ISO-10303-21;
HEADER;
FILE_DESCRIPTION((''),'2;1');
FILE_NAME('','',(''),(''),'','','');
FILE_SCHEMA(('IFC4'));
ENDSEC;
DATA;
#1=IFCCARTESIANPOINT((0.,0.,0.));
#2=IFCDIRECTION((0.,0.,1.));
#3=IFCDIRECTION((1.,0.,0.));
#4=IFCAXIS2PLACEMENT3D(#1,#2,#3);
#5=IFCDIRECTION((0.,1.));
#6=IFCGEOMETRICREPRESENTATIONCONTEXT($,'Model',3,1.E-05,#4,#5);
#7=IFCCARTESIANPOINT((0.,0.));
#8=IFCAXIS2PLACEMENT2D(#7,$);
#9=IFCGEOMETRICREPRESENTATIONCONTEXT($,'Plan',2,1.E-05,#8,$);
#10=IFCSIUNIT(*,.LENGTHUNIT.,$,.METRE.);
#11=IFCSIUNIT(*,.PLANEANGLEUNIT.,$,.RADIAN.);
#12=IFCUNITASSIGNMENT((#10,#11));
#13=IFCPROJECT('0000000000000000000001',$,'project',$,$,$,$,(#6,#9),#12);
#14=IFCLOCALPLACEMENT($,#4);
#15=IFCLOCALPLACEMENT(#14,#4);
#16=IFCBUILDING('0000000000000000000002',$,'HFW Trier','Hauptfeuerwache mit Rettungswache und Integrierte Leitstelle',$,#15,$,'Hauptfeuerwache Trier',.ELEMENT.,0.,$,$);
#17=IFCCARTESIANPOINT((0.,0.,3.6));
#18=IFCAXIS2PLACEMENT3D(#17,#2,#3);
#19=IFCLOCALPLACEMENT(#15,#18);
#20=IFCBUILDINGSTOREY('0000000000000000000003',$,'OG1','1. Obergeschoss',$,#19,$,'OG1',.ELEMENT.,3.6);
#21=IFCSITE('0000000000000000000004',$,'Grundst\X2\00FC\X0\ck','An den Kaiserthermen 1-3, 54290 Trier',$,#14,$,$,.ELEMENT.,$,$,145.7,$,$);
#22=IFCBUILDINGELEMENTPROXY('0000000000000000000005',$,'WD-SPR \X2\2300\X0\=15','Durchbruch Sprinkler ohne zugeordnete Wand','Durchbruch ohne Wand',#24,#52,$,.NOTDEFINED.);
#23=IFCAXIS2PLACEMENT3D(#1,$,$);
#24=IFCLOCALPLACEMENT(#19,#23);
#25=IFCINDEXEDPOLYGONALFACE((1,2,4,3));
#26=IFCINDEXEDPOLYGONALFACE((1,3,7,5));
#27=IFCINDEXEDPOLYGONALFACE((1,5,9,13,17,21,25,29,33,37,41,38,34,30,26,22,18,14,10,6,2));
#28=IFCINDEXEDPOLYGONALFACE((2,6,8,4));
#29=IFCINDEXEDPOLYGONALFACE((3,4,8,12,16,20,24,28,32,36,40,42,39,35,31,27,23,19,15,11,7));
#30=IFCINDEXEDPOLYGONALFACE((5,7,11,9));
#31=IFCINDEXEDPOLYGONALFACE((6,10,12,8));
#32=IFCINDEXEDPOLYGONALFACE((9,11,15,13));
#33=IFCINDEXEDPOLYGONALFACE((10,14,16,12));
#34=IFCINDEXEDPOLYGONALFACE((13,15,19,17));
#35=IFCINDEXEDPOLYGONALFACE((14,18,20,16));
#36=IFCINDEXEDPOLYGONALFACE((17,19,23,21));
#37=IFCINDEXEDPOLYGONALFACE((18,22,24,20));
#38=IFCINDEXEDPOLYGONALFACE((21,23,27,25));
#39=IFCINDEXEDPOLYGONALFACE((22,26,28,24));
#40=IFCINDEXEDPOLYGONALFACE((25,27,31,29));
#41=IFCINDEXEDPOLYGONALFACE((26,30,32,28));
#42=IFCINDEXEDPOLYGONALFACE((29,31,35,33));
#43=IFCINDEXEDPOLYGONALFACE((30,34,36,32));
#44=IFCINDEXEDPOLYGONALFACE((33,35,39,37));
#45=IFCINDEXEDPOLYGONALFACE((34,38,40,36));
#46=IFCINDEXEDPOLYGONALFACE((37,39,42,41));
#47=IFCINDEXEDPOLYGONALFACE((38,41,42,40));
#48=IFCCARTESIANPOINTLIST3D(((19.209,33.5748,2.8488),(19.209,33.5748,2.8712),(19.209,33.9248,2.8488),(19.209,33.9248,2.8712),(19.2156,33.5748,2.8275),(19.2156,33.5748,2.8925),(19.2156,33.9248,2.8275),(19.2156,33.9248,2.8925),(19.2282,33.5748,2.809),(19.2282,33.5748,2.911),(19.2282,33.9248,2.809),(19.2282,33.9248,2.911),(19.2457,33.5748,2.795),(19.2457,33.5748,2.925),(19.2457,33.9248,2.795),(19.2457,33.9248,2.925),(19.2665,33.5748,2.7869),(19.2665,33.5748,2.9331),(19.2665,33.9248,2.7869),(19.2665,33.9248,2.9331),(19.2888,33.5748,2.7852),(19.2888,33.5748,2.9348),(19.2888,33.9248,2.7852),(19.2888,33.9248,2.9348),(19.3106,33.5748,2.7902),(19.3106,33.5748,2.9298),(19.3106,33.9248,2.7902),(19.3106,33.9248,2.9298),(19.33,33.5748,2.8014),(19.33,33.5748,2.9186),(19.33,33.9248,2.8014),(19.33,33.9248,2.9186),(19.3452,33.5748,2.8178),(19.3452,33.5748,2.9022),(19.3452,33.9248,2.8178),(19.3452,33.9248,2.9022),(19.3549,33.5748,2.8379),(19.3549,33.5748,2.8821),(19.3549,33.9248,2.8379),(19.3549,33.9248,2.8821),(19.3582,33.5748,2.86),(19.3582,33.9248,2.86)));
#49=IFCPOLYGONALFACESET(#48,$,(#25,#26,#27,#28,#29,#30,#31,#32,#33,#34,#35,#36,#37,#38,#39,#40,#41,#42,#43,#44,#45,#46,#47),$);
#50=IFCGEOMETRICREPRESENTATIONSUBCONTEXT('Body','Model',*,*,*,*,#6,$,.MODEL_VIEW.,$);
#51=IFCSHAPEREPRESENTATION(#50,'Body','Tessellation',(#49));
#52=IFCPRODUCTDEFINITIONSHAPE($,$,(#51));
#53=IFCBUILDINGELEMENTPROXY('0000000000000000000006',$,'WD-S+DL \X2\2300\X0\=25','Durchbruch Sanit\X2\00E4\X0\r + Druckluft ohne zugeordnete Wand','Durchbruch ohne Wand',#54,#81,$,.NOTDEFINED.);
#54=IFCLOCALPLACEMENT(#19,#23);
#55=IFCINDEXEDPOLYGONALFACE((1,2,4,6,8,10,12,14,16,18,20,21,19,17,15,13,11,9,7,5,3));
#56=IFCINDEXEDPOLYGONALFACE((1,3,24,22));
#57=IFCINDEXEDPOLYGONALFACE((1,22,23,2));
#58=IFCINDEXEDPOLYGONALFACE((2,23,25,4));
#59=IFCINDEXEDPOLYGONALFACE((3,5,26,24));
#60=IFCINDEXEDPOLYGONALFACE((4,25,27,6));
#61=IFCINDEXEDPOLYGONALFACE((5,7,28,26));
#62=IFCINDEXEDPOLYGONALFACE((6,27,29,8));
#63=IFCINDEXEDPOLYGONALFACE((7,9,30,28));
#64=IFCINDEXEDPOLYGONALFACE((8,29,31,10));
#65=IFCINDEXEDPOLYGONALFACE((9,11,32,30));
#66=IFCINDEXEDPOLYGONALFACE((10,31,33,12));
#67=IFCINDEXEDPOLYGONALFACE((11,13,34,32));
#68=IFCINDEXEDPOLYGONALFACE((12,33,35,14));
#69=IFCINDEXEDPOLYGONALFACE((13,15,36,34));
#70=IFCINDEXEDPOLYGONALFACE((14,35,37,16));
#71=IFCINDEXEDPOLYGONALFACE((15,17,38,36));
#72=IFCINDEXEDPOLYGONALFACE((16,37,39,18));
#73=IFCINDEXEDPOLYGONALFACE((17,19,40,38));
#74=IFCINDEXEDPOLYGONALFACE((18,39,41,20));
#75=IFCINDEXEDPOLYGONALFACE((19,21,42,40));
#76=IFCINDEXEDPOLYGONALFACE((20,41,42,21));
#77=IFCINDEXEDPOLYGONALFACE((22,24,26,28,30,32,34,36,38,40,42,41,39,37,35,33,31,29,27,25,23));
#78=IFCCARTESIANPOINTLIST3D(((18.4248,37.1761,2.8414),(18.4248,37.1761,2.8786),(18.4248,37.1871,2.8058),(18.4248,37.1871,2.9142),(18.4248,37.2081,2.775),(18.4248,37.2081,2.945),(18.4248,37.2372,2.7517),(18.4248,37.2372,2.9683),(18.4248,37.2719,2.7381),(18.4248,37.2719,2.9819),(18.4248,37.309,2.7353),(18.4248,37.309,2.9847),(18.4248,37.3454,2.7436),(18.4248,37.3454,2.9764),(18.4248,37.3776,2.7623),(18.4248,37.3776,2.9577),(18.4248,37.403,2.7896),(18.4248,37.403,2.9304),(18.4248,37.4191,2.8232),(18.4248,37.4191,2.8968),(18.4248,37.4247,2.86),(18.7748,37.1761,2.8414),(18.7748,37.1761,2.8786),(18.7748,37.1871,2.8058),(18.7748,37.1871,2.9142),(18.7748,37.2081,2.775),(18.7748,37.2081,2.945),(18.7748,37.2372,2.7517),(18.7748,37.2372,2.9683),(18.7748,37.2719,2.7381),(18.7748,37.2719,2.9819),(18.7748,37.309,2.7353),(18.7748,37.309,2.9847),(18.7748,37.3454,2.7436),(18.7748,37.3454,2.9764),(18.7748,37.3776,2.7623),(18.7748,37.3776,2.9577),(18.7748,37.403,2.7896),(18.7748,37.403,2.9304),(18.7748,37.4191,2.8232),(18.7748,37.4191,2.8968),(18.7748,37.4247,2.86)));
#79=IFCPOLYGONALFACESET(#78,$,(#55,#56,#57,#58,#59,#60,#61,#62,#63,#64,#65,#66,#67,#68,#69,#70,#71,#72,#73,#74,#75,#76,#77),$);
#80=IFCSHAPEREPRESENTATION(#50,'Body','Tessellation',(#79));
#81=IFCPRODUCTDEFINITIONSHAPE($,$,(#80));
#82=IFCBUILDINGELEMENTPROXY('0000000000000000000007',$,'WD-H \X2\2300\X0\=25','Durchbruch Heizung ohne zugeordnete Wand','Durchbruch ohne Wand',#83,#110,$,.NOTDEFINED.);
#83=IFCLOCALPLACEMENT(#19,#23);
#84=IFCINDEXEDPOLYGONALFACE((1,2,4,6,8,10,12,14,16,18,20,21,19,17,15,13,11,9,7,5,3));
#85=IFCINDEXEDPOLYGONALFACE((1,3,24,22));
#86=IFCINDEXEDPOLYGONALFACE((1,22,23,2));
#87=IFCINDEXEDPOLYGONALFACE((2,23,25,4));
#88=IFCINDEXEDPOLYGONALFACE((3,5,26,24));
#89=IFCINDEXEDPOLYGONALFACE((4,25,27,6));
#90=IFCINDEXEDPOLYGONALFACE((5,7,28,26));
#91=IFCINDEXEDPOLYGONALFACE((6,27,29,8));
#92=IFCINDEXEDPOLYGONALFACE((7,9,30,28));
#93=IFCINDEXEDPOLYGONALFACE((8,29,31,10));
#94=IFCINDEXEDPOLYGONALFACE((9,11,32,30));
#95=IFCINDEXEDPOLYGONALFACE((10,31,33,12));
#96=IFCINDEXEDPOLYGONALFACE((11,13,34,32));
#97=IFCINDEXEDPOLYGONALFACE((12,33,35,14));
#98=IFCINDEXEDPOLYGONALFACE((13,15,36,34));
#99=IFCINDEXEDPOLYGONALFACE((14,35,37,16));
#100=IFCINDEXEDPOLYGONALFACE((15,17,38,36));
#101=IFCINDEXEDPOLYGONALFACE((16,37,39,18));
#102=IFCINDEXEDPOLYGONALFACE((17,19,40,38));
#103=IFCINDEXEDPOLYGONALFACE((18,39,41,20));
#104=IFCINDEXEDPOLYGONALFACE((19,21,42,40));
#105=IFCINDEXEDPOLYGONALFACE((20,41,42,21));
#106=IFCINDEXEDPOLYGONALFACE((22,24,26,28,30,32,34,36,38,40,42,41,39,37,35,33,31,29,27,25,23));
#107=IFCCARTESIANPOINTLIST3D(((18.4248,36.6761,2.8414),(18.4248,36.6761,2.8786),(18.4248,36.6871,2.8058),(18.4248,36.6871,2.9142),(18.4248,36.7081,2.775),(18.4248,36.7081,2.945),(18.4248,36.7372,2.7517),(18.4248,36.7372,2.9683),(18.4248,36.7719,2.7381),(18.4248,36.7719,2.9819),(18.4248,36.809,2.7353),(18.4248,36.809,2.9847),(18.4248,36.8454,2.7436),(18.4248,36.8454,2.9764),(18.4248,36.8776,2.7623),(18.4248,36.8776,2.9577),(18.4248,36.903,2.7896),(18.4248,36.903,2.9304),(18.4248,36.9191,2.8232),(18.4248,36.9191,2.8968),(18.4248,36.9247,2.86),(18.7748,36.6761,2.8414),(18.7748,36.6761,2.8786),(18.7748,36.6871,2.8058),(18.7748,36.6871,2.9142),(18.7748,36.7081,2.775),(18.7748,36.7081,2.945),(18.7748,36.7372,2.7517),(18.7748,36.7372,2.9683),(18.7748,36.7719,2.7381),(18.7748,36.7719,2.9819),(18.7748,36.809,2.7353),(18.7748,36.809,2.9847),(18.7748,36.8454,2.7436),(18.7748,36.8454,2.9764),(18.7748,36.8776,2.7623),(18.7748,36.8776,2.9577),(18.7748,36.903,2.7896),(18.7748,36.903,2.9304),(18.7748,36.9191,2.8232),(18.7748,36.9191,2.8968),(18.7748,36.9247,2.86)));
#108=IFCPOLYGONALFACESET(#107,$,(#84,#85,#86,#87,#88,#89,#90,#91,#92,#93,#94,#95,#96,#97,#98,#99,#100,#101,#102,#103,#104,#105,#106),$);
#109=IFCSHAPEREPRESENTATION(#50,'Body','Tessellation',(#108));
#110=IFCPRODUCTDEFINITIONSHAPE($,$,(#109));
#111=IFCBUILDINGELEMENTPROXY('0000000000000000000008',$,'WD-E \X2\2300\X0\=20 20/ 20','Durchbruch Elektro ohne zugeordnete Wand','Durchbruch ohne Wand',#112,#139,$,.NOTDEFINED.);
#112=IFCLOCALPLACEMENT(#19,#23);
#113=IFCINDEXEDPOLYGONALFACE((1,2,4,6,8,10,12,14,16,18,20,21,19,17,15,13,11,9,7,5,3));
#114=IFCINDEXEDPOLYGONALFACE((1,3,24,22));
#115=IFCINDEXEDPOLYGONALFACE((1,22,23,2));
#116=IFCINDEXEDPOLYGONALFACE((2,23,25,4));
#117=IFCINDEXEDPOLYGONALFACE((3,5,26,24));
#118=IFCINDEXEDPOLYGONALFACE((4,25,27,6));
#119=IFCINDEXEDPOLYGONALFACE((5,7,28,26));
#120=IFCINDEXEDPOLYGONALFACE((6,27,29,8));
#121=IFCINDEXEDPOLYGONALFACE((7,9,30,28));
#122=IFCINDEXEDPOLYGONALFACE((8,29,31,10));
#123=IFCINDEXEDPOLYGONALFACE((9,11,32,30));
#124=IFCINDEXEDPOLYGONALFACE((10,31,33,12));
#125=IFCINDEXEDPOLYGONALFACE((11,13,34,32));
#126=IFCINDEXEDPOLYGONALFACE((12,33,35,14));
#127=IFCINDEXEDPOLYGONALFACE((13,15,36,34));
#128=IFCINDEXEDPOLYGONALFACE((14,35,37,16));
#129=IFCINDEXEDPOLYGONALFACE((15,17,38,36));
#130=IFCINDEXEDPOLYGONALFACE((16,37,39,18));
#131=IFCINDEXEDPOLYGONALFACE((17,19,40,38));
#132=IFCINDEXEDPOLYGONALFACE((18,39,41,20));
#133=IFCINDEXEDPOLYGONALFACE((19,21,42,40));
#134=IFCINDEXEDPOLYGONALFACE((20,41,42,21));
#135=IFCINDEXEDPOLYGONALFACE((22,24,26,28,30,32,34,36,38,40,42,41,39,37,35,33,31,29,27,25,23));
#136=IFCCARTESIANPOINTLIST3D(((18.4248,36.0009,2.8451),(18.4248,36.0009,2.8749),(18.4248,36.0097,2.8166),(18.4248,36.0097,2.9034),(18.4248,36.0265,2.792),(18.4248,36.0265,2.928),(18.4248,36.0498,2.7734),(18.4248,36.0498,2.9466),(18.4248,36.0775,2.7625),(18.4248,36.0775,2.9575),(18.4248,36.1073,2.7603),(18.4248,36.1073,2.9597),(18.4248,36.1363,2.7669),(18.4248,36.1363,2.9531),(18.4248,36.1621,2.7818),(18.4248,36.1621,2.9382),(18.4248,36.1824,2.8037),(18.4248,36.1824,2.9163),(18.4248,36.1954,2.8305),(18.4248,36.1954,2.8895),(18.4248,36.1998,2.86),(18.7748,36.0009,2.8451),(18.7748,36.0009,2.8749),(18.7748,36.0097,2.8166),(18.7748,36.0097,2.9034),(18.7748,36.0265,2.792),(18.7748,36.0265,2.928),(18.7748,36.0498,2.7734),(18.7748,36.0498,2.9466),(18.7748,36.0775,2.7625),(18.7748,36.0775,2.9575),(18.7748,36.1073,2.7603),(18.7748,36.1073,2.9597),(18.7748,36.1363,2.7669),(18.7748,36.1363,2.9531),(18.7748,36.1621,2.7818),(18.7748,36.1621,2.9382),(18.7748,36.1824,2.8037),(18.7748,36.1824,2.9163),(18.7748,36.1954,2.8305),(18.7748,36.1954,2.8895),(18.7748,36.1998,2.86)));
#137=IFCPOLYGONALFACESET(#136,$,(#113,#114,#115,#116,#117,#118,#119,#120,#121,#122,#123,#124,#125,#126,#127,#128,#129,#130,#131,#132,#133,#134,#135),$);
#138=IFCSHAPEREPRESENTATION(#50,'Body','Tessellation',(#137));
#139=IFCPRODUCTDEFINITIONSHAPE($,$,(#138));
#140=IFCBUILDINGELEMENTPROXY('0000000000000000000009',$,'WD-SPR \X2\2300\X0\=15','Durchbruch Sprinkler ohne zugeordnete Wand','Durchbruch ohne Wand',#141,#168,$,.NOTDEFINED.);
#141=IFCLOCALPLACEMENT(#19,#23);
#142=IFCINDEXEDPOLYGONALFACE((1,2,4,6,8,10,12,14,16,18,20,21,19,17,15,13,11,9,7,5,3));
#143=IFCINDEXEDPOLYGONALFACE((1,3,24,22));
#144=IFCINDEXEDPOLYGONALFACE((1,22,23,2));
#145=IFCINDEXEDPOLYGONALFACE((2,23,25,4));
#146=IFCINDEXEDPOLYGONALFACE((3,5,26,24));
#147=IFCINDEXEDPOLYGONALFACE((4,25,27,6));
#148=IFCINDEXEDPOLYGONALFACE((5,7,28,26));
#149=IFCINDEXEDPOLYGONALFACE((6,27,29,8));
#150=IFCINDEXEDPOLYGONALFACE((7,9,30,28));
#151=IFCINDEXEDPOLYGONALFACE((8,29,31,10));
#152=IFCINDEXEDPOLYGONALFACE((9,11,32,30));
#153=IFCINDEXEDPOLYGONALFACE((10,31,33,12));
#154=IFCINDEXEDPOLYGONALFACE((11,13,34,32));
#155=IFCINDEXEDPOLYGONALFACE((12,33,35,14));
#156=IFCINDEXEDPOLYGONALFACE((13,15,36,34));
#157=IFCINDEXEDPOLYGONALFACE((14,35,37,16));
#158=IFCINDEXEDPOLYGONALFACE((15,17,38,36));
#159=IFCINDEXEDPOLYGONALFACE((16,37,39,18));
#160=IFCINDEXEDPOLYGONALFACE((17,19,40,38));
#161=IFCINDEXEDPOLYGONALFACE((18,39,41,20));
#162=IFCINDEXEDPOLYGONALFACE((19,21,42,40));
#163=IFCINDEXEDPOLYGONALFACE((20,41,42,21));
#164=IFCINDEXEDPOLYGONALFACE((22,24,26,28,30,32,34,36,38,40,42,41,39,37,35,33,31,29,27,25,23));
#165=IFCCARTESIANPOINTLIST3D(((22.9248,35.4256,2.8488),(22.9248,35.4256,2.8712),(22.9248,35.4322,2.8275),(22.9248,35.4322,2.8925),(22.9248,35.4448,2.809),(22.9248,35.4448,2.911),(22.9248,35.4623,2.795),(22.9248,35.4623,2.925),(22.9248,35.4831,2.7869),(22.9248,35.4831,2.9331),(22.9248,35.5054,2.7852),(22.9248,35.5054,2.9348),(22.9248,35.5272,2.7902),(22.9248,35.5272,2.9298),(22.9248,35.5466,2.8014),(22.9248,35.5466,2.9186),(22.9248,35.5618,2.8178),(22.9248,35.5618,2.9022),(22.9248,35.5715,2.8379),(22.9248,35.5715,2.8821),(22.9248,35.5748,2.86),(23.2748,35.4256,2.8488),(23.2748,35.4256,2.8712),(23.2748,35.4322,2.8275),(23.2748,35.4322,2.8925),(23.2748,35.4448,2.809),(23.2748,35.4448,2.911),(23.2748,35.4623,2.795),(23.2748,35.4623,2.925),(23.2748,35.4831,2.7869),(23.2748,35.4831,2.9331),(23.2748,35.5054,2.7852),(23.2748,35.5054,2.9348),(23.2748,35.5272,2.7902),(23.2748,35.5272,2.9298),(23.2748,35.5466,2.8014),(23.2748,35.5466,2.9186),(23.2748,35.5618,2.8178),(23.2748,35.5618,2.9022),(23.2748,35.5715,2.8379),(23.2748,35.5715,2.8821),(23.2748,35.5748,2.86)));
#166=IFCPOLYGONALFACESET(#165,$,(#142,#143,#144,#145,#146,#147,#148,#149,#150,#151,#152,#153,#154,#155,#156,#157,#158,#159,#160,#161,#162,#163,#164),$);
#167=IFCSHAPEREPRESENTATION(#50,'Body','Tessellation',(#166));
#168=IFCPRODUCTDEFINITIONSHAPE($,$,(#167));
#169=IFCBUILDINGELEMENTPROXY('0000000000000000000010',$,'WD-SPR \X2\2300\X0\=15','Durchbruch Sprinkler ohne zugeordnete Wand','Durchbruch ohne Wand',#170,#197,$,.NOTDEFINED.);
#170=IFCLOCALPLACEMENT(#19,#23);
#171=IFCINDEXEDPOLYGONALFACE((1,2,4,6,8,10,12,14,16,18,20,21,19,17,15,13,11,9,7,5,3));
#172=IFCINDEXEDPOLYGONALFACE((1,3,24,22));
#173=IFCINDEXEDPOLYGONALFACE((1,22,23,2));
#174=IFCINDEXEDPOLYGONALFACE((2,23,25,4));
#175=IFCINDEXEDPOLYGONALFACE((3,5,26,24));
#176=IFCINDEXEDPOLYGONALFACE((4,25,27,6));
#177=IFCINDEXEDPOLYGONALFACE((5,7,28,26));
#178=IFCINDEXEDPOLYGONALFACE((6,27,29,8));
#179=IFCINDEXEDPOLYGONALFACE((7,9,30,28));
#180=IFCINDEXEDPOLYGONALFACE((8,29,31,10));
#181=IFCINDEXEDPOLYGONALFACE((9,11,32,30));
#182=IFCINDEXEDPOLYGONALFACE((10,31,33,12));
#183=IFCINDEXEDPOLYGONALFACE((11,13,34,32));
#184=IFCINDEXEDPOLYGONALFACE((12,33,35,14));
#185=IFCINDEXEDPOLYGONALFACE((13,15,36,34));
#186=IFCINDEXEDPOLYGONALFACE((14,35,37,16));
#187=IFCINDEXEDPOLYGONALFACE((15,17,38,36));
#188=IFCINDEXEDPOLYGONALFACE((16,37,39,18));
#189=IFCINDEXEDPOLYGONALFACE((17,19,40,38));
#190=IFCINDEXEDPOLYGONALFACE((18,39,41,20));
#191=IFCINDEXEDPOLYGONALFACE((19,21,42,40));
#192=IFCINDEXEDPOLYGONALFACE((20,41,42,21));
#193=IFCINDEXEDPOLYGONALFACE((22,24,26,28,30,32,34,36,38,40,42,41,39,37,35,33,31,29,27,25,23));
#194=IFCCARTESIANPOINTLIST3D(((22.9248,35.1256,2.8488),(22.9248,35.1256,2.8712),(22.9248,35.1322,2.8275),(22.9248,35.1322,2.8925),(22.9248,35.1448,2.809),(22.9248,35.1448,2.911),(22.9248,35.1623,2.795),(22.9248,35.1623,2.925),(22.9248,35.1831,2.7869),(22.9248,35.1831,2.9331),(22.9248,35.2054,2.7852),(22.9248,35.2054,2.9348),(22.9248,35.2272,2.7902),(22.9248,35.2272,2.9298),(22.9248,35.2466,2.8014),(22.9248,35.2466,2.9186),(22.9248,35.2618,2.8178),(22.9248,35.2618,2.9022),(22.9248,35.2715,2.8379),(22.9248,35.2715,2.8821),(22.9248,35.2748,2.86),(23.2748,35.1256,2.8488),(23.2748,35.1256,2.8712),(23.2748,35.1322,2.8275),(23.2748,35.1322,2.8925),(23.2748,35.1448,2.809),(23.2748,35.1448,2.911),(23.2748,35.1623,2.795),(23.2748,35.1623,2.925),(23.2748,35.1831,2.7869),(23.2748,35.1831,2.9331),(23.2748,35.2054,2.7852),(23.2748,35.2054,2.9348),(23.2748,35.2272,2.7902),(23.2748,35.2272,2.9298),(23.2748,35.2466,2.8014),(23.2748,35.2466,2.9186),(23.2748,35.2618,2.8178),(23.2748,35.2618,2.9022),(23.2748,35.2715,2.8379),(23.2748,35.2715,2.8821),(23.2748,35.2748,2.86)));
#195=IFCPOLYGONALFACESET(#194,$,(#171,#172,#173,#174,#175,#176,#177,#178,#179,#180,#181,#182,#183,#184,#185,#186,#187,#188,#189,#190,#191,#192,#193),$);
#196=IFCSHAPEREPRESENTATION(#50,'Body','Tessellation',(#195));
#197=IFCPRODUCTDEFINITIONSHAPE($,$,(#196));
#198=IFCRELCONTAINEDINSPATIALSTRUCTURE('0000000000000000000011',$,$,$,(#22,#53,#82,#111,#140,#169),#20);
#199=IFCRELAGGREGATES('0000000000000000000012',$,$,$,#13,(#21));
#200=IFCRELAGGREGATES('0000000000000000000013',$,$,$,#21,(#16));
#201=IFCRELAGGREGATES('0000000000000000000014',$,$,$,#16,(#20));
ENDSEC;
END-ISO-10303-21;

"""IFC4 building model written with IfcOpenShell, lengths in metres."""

from ifc_helpers import new_model, si_unit, direction, frame, origin_with_axes, origin_2d, place, context, subcontext, project, spatial, circle, extrude, element, save


model = new_model("IFC4")

# Units and contexts
model_context = context("Model", 3, precision=1e-05, world=origin_with_axes(), true_north=direction((0.0, 1.0)))
plan_context = context("Plan", 2, precision=1e-05, world=origin_2d())
body_context = subcontext(model_context, "Body", "Model", "MODEL_VIEW")
ifc_project = project(units=[si_unit("LENGTHUNIT", "METRE"), si_unit("PLANEANGLEUNIT", "RADIAN")], contexts=[model_context, plan_context])

# Site, building, storey
site_placement = place(None, origin_with_axes())
site = spatial("IfcSite", under=ifc_project, at=site_placement, Name="Grundstück", Description="An den Kaiserthermen 1-3, 54290 Trier", CompositionType="ELEMENT", RefElevation=145.7)
building_placement = place(site_placement, origin_with_axes())
building = spatial("IfcBuilding", under=site, at=building_placement, Name="HFW Trier", Description="Hauptfeuerwache mit Rettungswache und Integrierte Leitstelle", LongName="Hauptfeuerwache Trier", CompositionType="ELEMENT", ElevationOfRefHeight=0.0)
storey_placement = place(building_placement, frame((0.0, 0.0, 3.6), z_axis=(0.0, 0.0, 1.0), x_axis=(1.0, 0.0, 0.0)))
storey = spatial("IfcBuildingStorey", under=building, at=storey_placement, Name="OG1", Description="1. Obergeschoss", LongName="OG1", CompositionType="ELEMENT", Elevation=3.6)

# Building element proxies
for number, where, z_axis, x_axis, name in (
    (1, (19.2832, 33.7498, 2.785), (0.0, 0.0, 1.0), (1.0, 0.0, 0.0), "WD-SPR ⌀=15"),
):
    element("IfcBuildingElementProxy", number, at=place(storey_placement, frame(where, z_axis=z_axis, x_axis=x_axis)), inside=storey, Name=name, Description="Durchbruch Sprinkler ohne zugeordnete Wand", ObjectType="Durchbruch ohne Wand", PredefinedType="NOTDEFINED", context=body_context, shape_type="SweptSolid", body=[
        extrude(circle(Radius=0.075, at=origin_2d()), frame((0.0, -0.175, 0.075), z_axis=(0.0, 1.0, 0.0), x_axis=(1.0, 0.0, 0.0)), (0.0, 0.0, 1.0), 0.35),
    ])
for number, where, z_axis, x_axis, name, description in (
    (2, (18.5998, 37.2997, 2.735), (0.0, 0.0, 1.0), (0.0, 1.0, 0.0), "WD-S+DL ⌀=25", "Durchbruch Sanitär + Druckluft ohne zugeordnete Wand"),
    (3, (18.5998, 36.7997, 2.735), (0.0, 0.0, 1.0), (0.0, 1.0, 0.0), "WD-H ⌀=25", "Durchbruch Heizung ohne zugeordnete Wand"),
):
    element("IfcBuildingElementProxy", number, at=place(storey_placement, frame(where, z_axis=z_axis, x_axis=x_axis)), inside=storey, Name=name, Description=description, ObjectType="Durchbruch ohne Wand", PredefinedType="NOTDEFINED", context=body_context, shape_type="SweptSolid", body=[
        extrude(circle(Radius=0.125, at=origin_2d()), frame((0.0, -0.175, 0.125), z_axis=(0.0, 1.0, 0.0), x_axis=(1.0, 0.0, 0.0)), (0.0, 0.0, 1.0), 0.35),
    ])
proxy_1_placement = place(storey_placement, frame((18.5998, 36.0998, 2.76), z_axis=(0.0, 0.0, 1.0), x_axis=(0.0, 1.0, 0.0)))
element("IfcBuildingElementProxy", 4, at=proxy_1_placement, inside=storey, Name="WD-E ⌀=20 20/ 20", Description="Durchbruch Elektro ohne zugeordnete Wand", ObjectType="Durchbruch ohne Wand", PredefinedType="NOTDEFINED", context=body_context, shape_type="SweptSolid", body=[
    extrude(circle(Radius=0.1, at=origin_2d()), frame((0.0, -0.175, 0.1), z_axis=(0.0, 1.0, 0.0), x_axis=(1.0, 0.0, 0.0)), (0.0, 0.0, 1.0), 0.35),
])
for number, where, z_axis, x_axis, name in (
    (5, (23.0998, 35.4998, 2.785), (0.0, 0.0, 1.0), (0.0, 1.0, 0.0), "WD-SPR ⌀=15"),
    (6, (23.0998, 35.1998, 2.785), (0.0, 0.0, 1.0), (0.0, 1.0, 0.0), "WD-SPR ⌀=15"),
):
    element("IfcBuildingElementProxy", number, at=place(storey_placement, frame(where, z_axis=z_axis, x_axis=x_axis)), inside=storey, Name=name, Description="Durchbruch Sprinkler ohne zugeordnete Wand", ObjectType="Durchbruch ohne Wand", PredefinedType="NOTDEFINED", context=body_context, shape_type="SweptSolid", body=[
        extrude(circle(Radius=0.075, at=origin_2d()), frame((0.0, -0.175, 0.075), z_axis=(0.0, 1.0, 0.0), x_axis=(1.0, 0.0, 0.0)), (0.0, 0.0, 1.0), 0.35),
    ])

save(model, "model.ifc")
